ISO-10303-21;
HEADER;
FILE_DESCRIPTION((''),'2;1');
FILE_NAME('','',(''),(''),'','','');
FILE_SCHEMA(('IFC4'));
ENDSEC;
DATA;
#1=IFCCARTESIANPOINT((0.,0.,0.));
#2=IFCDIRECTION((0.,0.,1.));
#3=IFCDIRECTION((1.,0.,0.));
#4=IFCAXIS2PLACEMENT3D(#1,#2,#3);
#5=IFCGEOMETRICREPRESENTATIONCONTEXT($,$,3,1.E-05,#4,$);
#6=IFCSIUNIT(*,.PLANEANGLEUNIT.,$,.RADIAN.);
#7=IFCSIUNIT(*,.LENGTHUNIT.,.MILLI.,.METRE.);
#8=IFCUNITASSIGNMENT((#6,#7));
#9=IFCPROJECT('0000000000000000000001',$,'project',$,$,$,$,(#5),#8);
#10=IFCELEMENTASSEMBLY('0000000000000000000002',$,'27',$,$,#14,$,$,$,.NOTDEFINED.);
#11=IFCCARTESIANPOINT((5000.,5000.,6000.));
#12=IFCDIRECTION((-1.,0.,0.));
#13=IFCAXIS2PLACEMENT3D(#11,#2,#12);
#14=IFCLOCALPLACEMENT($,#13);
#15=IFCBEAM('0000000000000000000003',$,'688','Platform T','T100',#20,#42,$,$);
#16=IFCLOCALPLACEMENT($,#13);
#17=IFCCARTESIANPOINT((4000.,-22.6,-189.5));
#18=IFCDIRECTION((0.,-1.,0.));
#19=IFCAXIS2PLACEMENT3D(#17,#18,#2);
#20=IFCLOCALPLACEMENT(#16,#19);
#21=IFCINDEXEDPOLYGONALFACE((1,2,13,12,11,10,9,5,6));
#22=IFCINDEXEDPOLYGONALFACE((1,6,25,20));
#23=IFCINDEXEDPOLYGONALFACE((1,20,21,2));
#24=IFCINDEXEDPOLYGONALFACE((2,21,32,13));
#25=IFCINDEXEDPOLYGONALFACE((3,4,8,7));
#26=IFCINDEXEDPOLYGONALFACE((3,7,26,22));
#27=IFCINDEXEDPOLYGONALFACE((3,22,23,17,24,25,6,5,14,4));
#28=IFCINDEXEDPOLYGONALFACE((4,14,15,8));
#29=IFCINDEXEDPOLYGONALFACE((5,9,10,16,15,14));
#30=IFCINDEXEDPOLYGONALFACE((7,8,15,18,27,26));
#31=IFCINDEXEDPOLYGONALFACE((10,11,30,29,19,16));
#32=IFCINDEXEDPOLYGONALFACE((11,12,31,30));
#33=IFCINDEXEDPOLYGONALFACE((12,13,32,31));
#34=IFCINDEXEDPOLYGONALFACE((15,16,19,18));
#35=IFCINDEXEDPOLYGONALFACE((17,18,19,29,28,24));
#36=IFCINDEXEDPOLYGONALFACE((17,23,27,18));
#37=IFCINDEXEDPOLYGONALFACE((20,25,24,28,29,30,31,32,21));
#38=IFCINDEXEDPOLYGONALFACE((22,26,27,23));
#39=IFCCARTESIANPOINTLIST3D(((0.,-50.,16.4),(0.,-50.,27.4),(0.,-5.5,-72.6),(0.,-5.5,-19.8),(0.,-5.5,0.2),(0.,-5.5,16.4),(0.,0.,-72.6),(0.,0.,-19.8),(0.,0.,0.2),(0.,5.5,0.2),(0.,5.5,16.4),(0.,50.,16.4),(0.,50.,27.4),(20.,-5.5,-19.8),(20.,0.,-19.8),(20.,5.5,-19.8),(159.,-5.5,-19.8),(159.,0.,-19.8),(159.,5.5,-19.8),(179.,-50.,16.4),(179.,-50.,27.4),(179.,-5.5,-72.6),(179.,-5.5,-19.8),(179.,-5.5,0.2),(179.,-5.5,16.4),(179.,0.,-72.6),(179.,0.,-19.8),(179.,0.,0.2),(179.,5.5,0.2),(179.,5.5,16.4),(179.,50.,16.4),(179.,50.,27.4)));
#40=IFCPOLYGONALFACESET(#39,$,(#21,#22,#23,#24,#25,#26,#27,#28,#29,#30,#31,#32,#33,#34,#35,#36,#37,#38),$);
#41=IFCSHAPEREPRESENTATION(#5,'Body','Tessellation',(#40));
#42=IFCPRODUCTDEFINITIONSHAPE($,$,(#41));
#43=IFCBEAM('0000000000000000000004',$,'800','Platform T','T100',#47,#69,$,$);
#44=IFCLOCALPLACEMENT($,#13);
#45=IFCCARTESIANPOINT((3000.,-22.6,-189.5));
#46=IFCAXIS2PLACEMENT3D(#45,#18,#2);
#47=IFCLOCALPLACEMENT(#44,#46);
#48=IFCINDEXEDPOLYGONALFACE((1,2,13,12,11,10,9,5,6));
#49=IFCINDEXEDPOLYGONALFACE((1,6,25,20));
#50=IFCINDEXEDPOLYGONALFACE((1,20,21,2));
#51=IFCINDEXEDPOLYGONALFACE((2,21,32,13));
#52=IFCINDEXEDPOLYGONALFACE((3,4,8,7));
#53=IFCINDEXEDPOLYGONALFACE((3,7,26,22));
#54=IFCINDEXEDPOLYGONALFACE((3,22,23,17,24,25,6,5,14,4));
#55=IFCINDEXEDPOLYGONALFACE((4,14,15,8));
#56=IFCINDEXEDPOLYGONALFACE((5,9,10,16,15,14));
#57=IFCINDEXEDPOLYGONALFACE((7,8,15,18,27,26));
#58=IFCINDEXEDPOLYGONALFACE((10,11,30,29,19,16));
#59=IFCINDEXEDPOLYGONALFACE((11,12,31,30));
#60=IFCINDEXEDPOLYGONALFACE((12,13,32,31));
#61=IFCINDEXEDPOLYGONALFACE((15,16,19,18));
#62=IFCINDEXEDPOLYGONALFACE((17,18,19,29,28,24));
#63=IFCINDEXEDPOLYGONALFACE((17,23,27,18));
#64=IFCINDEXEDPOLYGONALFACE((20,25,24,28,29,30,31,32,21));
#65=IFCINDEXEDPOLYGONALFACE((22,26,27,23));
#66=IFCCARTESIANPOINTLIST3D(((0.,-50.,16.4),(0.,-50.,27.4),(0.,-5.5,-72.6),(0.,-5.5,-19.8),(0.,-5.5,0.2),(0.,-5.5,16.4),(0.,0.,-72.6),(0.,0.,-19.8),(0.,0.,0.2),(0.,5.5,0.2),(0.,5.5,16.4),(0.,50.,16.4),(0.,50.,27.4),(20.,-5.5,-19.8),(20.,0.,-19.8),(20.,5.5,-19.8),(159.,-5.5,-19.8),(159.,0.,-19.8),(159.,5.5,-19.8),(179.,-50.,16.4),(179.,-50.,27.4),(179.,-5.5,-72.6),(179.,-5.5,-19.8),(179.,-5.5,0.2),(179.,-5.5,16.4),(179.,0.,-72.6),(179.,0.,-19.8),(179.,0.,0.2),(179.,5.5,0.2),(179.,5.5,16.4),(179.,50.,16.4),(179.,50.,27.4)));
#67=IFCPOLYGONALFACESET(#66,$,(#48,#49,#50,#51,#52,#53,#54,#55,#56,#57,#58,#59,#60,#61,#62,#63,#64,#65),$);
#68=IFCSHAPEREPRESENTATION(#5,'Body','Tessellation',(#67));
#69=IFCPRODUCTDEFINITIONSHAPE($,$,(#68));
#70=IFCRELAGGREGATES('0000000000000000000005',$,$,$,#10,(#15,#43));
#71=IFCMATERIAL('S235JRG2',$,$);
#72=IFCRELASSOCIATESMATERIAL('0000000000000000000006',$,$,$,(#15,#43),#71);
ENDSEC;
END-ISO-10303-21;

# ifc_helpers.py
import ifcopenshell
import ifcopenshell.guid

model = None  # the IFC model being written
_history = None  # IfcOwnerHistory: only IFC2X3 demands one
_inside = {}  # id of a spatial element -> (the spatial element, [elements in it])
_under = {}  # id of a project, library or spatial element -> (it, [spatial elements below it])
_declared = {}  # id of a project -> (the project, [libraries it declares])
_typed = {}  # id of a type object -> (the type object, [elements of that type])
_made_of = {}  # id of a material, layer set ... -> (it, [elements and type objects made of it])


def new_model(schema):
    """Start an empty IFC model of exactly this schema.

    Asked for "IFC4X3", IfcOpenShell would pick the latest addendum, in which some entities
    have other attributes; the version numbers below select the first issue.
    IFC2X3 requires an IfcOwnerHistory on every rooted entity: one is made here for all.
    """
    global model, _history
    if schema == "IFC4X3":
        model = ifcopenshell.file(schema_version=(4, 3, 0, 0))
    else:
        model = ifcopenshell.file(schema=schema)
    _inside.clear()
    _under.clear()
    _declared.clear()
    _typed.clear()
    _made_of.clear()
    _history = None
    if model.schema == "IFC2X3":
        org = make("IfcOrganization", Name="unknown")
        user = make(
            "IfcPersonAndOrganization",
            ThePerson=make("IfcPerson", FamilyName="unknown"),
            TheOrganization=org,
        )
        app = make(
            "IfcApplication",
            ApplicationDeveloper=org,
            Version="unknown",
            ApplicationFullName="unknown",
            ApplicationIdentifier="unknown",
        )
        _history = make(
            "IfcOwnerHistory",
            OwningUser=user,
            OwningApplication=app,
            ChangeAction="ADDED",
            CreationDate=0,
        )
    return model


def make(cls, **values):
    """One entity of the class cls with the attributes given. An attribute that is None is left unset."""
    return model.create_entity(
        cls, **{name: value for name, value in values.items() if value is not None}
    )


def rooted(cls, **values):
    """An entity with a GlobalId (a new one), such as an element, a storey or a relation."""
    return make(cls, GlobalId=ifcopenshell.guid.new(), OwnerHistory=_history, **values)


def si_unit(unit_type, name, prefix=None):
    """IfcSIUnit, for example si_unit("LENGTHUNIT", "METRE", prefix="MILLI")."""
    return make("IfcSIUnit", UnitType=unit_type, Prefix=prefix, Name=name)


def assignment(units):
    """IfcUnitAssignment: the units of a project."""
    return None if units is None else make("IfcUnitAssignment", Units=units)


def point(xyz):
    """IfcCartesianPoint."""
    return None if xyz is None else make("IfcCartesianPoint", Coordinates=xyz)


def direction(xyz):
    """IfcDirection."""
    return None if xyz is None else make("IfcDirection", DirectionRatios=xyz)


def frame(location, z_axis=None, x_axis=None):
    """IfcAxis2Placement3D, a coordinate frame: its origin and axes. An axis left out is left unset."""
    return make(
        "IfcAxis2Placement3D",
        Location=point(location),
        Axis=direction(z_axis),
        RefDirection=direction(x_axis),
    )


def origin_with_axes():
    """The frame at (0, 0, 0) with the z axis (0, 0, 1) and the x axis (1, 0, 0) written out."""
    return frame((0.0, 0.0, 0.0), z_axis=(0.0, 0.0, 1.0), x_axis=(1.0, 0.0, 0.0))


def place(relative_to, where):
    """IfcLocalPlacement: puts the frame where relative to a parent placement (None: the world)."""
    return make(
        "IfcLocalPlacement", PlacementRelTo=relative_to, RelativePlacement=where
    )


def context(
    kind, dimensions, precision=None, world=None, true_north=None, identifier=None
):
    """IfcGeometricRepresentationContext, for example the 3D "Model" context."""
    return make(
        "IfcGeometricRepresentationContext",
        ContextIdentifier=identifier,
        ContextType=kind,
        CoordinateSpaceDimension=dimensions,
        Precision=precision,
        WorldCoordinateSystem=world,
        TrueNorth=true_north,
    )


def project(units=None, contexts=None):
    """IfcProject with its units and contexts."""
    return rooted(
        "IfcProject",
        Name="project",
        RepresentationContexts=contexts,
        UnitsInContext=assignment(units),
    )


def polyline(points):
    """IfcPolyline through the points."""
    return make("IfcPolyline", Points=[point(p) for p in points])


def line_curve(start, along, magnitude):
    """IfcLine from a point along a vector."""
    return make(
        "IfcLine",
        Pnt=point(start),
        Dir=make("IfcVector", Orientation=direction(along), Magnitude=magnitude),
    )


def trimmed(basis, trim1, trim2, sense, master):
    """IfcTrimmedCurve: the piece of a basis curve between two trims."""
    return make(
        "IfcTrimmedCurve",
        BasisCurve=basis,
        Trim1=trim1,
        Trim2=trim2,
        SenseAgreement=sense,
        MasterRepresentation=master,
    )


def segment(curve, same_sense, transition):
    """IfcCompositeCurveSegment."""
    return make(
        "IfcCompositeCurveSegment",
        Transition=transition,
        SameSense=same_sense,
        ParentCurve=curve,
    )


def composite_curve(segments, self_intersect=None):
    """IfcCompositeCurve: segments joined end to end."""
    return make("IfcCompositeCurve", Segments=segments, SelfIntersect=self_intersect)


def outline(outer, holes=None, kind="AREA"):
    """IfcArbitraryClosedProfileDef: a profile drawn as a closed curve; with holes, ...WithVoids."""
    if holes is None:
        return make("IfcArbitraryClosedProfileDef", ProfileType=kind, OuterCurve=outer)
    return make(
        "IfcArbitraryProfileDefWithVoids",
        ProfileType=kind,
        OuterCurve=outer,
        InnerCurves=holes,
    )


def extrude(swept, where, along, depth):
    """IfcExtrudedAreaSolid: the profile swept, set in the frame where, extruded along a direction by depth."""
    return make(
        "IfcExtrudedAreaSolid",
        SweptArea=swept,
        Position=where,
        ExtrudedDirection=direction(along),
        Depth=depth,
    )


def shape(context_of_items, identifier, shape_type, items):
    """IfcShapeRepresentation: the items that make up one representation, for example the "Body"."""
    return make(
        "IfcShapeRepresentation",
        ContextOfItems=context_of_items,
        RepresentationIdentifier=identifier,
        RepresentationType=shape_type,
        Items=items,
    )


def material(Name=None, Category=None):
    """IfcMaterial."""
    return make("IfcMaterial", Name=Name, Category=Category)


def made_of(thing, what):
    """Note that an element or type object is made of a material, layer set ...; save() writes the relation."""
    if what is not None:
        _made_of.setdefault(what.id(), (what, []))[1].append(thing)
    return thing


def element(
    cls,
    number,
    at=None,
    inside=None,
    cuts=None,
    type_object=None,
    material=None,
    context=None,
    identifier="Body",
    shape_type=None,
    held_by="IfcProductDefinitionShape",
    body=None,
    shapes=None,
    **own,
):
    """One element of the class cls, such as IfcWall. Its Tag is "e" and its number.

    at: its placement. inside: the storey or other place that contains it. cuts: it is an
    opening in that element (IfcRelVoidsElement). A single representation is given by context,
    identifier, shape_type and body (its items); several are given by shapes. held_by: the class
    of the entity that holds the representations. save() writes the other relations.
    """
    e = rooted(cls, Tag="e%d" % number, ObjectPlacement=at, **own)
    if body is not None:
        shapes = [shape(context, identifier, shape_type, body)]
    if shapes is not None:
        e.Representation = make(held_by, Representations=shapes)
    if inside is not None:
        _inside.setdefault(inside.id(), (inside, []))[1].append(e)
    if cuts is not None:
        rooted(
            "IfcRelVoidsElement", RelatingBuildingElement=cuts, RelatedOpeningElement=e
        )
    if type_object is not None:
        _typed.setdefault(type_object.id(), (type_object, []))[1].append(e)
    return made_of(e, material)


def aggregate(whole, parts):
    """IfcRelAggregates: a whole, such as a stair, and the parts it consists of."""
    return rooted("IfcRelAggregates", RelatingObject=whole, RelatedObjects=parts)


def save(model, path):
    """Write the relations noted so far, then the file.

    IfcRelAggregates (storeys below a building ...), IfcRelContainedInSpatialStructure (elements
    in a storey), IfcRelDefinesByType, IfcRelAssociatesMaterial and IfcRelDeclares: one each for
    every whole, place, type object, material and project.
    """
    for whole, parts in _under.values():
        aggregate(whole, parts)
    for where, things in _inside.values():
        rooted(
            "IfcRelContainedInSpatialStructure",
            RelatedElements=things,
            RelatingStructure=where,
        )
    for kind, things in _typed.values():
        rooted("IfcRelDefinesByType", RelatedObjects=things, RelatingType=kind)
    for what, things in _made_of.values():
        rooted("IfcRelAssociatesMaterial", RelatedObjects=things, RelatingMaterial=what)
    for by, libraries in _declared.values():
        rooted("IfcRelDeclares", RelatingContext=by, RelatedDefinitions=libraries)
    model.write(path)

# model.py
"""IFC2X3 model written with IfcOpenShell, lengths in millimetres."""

from ifc_helpers import new_model, si_unit, point, frame, origin_with_axes, place, context, project, polyline, line_curve, trimmed, segment, composite_curve, outline, extrude, material, element, aggregate, save


model = new_model("IFC2X3")

# Units and contexts
context_of_model = context(None, 3, precision=1e-05, world=origin_with_axes())
ifc_project = project(units=[si_unit("PLANEANGLEUNIT", "RADIAN"), si_unit("LENGTHUNIT", "METRE", prefix="MILLI")], contexts=[context_of_model])

# Shared definitions
ifc_material = material(Name="S235JRG2")

# Element assembly, beams, openings
assembly_1_placement = place(None, frame((5000.0, 5000.0, 6000.0), z_axis=(0.0, 0.0, 1.0), x_axis=(-1.0, 0.0, 0.0)))
assembly_1 = element("IfcElementAssembly", 1, at=assembly_1_placement, Name="27", PredefinedType="NOTDEFINED")
placement_1 = place(None, frame((5000.0, 5000.0, 6000.0), z_axis=(0.0, 0.0, 1.0), x_axis=(-1.0, 0.0, 0.0)))
beam_1_placement = place(placement_1, frame((4000.0, -22.6, -189.5), z_axis=(0.0, -1.0, 0.0), x_axis=(0.0, 0.0, 1.0)))
beam_1 = element("IfcBeam", 2, at=beam_1_placement, material=ifc_material, Name="688", Description="Platform T", ObjectType="T100", context=context_of_model, shape_type="SweptSolid", body=[
    extrude(outline(polyline([(5.5, -72.6), (5.5, 16.4), (50.0, 16.4), (50.0, 27.4), (-50.0, 27.4), (-50.0, 16.4), (-5.5, 16.4), (-5.5, -72.6), (5.5, -72.6), (5.5, -72.6)])), frame((0.0, 0.0, 0.0), z_axis=(1.0, 0.0, 0.0), x_axis=(0.0, 1.0, 0.0)), (0.0, 0.0, 1.0), 179.0),
])
opening_1_placement = place(beam_1_placement, frame((179.0, 0.0, -72.6), z_axis=(0.0, 1.0, 0.0), x_axis=(0.0, 0.0, 1.0)))
element("IfcOpeningElement", 3, at=opening_1_placement, cuts=beam_1, ObjectType="Recess", context=context_of_model, shape_type="SweptSolid", body=[
    extrude(outline(composite_curve([segment(trimmed(line_curve((0.0, 0.0), (0.0, -1.0, 0.0), 179.0), [point((0.0, 0.0))], [point((0.0, -179.0))], True, "CARTESIAN"), True, "CONTINUOUS"), segment(trimmed(line_curve((0.0, -179.0), (1.0, 0.0, 0.0), 52.8), [point((0.0, -179.0))], [point((52.8, -179.0))], True, "CARTESIAN"), True, "CONTINUOUS"), segment(trimmed(line_curve((52.8, -179.0), (0.0, 1.0, 0.0), 179.0), [point((52.8, -179.0))], [point((52.8, 0.0))], True, "CARTESIAN"), True, "CONTINUOUS"), segment(trimmed(line_curve((52.8, 0.0), (-1.0, 0.0, 0.0), 52.8), [point((52.8, 0.0))], [point((0.0, 0.0))], True, "CARTESIAN"), True, "CONTINUOUS")], self_intersect=False)), origin_with_axes(), (0.0, 0.0, 1.0), 100.0),
])
opening_2_placement = place(beam_1_placement, frame((179.0, 0.0, -19.8), z_axis=(0.0, 1.0, 0.0), x_axis=(0.0, 0.0, 1.0)))
element("IfcOpeningElement", 4, at=opening_2_placement, cuts=beam_1, context=context_of_model, shape_type="SweptSolid", body=[
    extrude(outline(composite_curve([segment(trimmed(line_curve((0.0, 0.0), (1.0, 0.0, 0.0), 20.0), [point((0.0, 0.0))], [point((20.0, 0.0))], True, "CARTESIAN"), True, "CONTINUOUS"), segment(trimmed(line_curve((20.0, 0.0), (-0.707107, -0.707107, 0.0), 28.284271), [point((20.0, 0.0))], [point((0.0, -20.0))], True, "CARTESIAN"), True, "CONTINUOUS"), segment(trimmed(line_curve((0.0, -20.0), (0.0, 1.0, 0.0), 20.0), [point((0.0, -20.0))], [point((0.0, 0.0))], True, "CARTESIAN"), True, "CONTINUOUS")], self_intersect=False)), origin_with_axes(), (0.0, 0.0, 1.0), 100.0),
])
opening_3_placement = place(beam_1_placement, frame((179.0, 0.0, -19.8), z_axis=(0.0, -1.0, 0.0), x_axis=(0.0, 0.0, -1.0)))
element("IfcOpeningElement", 5, at=opening_3_placement, cuts=beam_1, context=context_of_model, shape_type="SweptSolid", body=[
    extrude(outline(composite_curve([segment(trimmed(line_curve((0.0, 0.0), (-1.0, 0.0, 0.0), 20.0), [point((0.0, 0.0))], [point((-20.0, 0.0))], True, "CARTESIAN"), True, "CONTINUOUS"), segment(trimmed(line_curve((-20.0, 0.0), (0.707107, -0.707107, 0.0), 28.284271), [point((-20.0, 0.0))], [point((0.0, -20.0))], True, "CARTESIAN"), True, "CONTINUOUS"), segment(trimmed(line_curve((0.0, -20.0), (0.0, 1.0, 0.0), 20.0), [point((0.0, -20.0))], [point((0.0, 0.0))], True, "CARTESIAN"), True, "CONTINUOUS")], self_intersect=False)), origin_with_axes(), (0.0, 0.0, 1.0), 100.0),
])
opening_4_placement = place(beam_1_placement, frame((0.0, 0.0, -19.8), z_axis=(0.0, -1.0, 0.0), x_axis=(0.0, 0.0, -1.0)))
element("IfcOpeningElement", 6, at=opening_4_placement, cuts=beam_1, context=context_of_model, shape_type="SweptSolid", body=[
    extrude(outline(composite_curve([segment(trimmed(line_curve((0.0, 0.0), (-1.0, 0.0, 0.0), 20.0), [point((0.0, 0.0))], [point((-20.0, 0.0))], True, "CARTESIAN"), True, "CONTINUOUS"), segment(trimmed(line_curve((-20.0, 0.0), (0.707107, 0.707107, 0.0), 28.284271), [point((-20.0, 0.0))], [point((0.0, 20.0))], True, "CARTESIAN"), True, "CONTINUOUS"), segment(trimmed(line_curve((0.0, 20.0), (0.0, -1.0, 0.0), 20.0), [point((0.0, 20.0))], [point((0.0, 0.0))], True, "CARTESIAN"), True, "CONTINUOUS")], self_intersect=False)), origin_with_axes(), (0.0, 0.0, 1.0), 100.0),
])
opening_5_placement = place(beam_1_placement, frame((0.0, 0.0, -19.8), z_axis=(0.0, 1.0, 0.0), x_axis=(0.0, 0.0, 1.0)))
element("IfcOpeningElement", 7, at=opening_5_placement, cuts=beam_1, context=context_of_model, shape_type="SweptSolid", body=[
    extrude(outline(composite_curve([segment(trimmed(line_curve((0.0, 0.0), (1.0, 0.0, 0.0), 20.0), [point((0.0, 0.0))], [point((20.0, 0.0))], True, "CARTESIAN"), True, "CONTINUOUS"), segment(trimmed(line_curve((20.0, 0.0), (-0.707107, 0.707107, 0.0), 28.284271), [point((20.0, 0.0))], [point((0.0, 20.0))], True, "CARTESIAN"), True, "CONTINUOUS"), segment(trimmed(line_curve((0.0, 20.0), (0.0, -1.0, 0.0), 20.0), [point((0.0, 20.0))], [point((0.0, 0.0))], True, "CARTESIAN"), True, "CONTINUOUS")], self_intersect=False)), origin_with_axes(), (0.0, 0.0, 1.0), 100.0),
])
placement_2 = place(None, frame((5000.0, 5000.0, 6000.0), z_axis=(0.0, 0.0, 1.0), x_axis=(-1.0, 0.0, 0.0)))
beam_2_placement = place(placement_2, frame((3000.0, -22.6, -189.5), z_axis=(0.0, -1.0, 0.0), x_axis=(0.0, 0.0, 1.0)))
beam_2 = element("IfcBeam", 8, at=beam_2_placement, material=ifc_material, Name="800", Description="Platform T", ObjectType="T100", context=context_of_model, shape_type="SweptSolid", body=[
    extrude(outline(polyline([(5.5, -72.6), (5.5, 16.4), (50.0, 16.4), (50.0, 27.4), (-50.0, 27.4), (-50.0, 16.4), (-5.5, 16.4), (-5.5, -72.6), (5.5, -72.6), (5.5, -72.6)])), frame((0.0, 0.0, 0.0), z_axis=(1.0, 0.0, 0.0), x_axis=(0.0, 1.0, 0.0)), (0.0, 0.0, 1.0), 179.0),
])
opening_6_placement = place(beam_2_placement, frame((179.0, 0.0, -72.6), z_axis=(0.0, 1.0, 0.0), x_axis=(0.0, 0.0, 1.0)))
element("IfcOpeningElement", 9, at=opening_6_placement, cuts=beam_2, ObjectType="Recess", context=context_of_model, shape_type="SweptSolid", body=[
    extrude(outline(composite_curve([segment(trimmed(line_curve((0.0, 0.0), (0.0, -1.0, 0.0), 179.0), [point((0.0, 0.0))], [point((0.0, -179.0))], True, "CARTESIAN"), True, "CONTINUOUS"), segment(trimmed(line_curve((0.0, -179.0), (1.0, 0.0, 0.0), 52.8), [point((0.0, -179.0))], [point((52.8, -179.0))], True, "CARTESIAN"), True, "CONTINUOUS"), segment(trimmed(line_curve((52.8, -179.0), (0.0, 1.0, 0.0), 179.0), [point((52.8, -179.0))], [point((52.8, 0.0))], True, "CARTESIAN"), True, "CONTINUOUS"), segment(trimmed(line_curve((52.8, 0.0), (-1.0, 0.0, 0.0), 52.8), [point((52.8, 0.0))], [point((0.0, 0.0))], True, "CARTESIAN"), True, "CONTINUOUS")], self_intersect=False)), origin_with_axes(), (0.0, 0.0, 1.0), 100.0),
])
opening_7_placement = place(beam_2_placement, frame((179.0, 0.0, -19.8), z_axis=(0.0, 1.0, 0.0), x_axis=(0.0, 0.0, 1.0)))
element("IfcOpeningElement", 10, at=opening_7_placement, cuts=beam_2, context=context_of_model, shape_type="SweptSolid", body=[
    extrude(outline(composite_curve([segment(trimmed(line_curve((0.0, 0.0), (1.0, 0.0, 0.0), 20.0), [point((0.0, 0.0))], [point((20.0, 0.0))], True, "CARTESIAN"), True, "CONTINUOUS"), segment(trimmed(line_curve((20.0, 0.0), (-0.707107, -0.707107, 0.0), 28.284271), [point((20.0, 0.0))], [point((0.0, -20.0))], True, "CARTESIAN"), True, "CONTINUOUS"), segment(trimmed(line_curve((0.0, -20.0), (0.0, 1.0, 0.0), 20.0), [point((0.0, -20.0))], [point((0.0, 0.0))], True, "CARTESIAN"), True, "CONTINUOUS")], self_intersect=False)), origin_with_axes(), (0.0, 0.0, 1.0), 100.0),
])
opening_8_placement = place(beam_2_placement, frame((179.0, 0.0, -19.8), z_axis=(0.0, -1.0, 0.0), x_axis=(0.0, 0.0, -1.0)))
element("IfcOpeningElement", 11, at=opening_8_placement, cuts=beam_2, context=context_of_model, shape_type="SweptSolid", body=[
    extrude(outline(composite_curve([segment(trimmed(line_curve((0.0, 0.0), (-1.0, 0.0, 0.0), 20.0), [point((0.0, 0.0))], [point((-20.0, 0.0))], True, "CARTESIAN"), True, "CONTINUOUS"), segment(trimmed(line_curve((-20.0, 0.0), (0.707107, -0.707107, 0.0), 28.284271), [point((-20.0, 0.0))], [point((0.0, -20.0))], True, "CARTESIAN"), True, "CONTINUOUS"), segment(trimmed(line_curve((0.0, -20.0), (0.0, 1.0, 0.0), 20.0), [point((0.0, -20.0))], [point((0.0, 0.0))], True, "CARTESIAN"), True, "CONTINUOUS")], self_intersect=False)), origin_with_axes(), (0.0, 0.0, 1.0), 100.0),
])
opening_9_placement = place(beam_2_placement, frame((0.0, 0.0, -19.8), z_axis=(0.0, -1.0, 0.0), x_axis=(0.0, 0.0, -1.0)))
element("IfcOpeningElement", 12, at=opening_9_placement, cuts=beam_2, context=context_of_model, shape_type="SweptSolid", body=[
    extrude(outline(composite_curve([segment(trimmed(line_curve((0.0, 0.0), (-1.0, 0.0, 0.0), 20.0), [point((0.0, 0.0))], [point((-20.0, 0.0))], True, "CARTESIAN"), True, "CONTINUOUS"), segment(trimmed(line_curve((-20.0, 0.0), (0.707107, 0.707107, 0.0), 28.284271), [point((-20.0, 0.0))], [point((0.0, 20.0))], True, "CARTESIAN"), True, "CONTINUOUS"), segment(trimmed(line_curve((0.0, 20.0), (0.0, -1.0, 0.0), 20.0), [point((0.0, 20.0))], [point((0.0, 0.0))], True, "CARTESIAN"), True, "CONTINUOUS")], self_intersect=False)), origin_with_axes(), (0.0, 0.0, 1.0), 100.0),
])
opening_10_placement = place(beam_2_placement, frame((0.0, 0.0, -19.8), z_axis=(0.0, 1.0, 0.0), x_axis=(0.0, 0.0, 1.0)))
element("IfcOpeningElement", 13, at=opening_10_placement, cuts=beam_2, context=context_of_model, shape_type="SweptSolid", body=[
    extrude(outline(composite_curve([segment(trimmed(line_curve((0.0, 0.0), (1.0, 0.0, 0.0), 20.0), [point((0.0, 0.0))], [point((20.0, 0.0))], True, "CARTESIAN"), True, "CONTINUOUS"), segment(trimmed(line_curve((20.0, 0.0), (-0.707107, 0.707107, 0.0), 28.284271), [point((20.0, 0.0))], [point((0.0, 20.0))], True, "CARTESIAN"), True, "CONTINUOUS"), segment(trimmed(line_curve((0.0, 20.0), (0.0, -1.0, 0.0), 20.0), [point((0.0, 20.0))], [point((0.0, 0.0))], True, "CARTESIAN"), True, "CONTINUOUS")], self_intersect=False)), origin_with_axes(), (0.0, 0.0, 1.0), 100.0),
])
aggregate(assembly_1, [beam_1, beam_2])

save(model, "model.ifc")
